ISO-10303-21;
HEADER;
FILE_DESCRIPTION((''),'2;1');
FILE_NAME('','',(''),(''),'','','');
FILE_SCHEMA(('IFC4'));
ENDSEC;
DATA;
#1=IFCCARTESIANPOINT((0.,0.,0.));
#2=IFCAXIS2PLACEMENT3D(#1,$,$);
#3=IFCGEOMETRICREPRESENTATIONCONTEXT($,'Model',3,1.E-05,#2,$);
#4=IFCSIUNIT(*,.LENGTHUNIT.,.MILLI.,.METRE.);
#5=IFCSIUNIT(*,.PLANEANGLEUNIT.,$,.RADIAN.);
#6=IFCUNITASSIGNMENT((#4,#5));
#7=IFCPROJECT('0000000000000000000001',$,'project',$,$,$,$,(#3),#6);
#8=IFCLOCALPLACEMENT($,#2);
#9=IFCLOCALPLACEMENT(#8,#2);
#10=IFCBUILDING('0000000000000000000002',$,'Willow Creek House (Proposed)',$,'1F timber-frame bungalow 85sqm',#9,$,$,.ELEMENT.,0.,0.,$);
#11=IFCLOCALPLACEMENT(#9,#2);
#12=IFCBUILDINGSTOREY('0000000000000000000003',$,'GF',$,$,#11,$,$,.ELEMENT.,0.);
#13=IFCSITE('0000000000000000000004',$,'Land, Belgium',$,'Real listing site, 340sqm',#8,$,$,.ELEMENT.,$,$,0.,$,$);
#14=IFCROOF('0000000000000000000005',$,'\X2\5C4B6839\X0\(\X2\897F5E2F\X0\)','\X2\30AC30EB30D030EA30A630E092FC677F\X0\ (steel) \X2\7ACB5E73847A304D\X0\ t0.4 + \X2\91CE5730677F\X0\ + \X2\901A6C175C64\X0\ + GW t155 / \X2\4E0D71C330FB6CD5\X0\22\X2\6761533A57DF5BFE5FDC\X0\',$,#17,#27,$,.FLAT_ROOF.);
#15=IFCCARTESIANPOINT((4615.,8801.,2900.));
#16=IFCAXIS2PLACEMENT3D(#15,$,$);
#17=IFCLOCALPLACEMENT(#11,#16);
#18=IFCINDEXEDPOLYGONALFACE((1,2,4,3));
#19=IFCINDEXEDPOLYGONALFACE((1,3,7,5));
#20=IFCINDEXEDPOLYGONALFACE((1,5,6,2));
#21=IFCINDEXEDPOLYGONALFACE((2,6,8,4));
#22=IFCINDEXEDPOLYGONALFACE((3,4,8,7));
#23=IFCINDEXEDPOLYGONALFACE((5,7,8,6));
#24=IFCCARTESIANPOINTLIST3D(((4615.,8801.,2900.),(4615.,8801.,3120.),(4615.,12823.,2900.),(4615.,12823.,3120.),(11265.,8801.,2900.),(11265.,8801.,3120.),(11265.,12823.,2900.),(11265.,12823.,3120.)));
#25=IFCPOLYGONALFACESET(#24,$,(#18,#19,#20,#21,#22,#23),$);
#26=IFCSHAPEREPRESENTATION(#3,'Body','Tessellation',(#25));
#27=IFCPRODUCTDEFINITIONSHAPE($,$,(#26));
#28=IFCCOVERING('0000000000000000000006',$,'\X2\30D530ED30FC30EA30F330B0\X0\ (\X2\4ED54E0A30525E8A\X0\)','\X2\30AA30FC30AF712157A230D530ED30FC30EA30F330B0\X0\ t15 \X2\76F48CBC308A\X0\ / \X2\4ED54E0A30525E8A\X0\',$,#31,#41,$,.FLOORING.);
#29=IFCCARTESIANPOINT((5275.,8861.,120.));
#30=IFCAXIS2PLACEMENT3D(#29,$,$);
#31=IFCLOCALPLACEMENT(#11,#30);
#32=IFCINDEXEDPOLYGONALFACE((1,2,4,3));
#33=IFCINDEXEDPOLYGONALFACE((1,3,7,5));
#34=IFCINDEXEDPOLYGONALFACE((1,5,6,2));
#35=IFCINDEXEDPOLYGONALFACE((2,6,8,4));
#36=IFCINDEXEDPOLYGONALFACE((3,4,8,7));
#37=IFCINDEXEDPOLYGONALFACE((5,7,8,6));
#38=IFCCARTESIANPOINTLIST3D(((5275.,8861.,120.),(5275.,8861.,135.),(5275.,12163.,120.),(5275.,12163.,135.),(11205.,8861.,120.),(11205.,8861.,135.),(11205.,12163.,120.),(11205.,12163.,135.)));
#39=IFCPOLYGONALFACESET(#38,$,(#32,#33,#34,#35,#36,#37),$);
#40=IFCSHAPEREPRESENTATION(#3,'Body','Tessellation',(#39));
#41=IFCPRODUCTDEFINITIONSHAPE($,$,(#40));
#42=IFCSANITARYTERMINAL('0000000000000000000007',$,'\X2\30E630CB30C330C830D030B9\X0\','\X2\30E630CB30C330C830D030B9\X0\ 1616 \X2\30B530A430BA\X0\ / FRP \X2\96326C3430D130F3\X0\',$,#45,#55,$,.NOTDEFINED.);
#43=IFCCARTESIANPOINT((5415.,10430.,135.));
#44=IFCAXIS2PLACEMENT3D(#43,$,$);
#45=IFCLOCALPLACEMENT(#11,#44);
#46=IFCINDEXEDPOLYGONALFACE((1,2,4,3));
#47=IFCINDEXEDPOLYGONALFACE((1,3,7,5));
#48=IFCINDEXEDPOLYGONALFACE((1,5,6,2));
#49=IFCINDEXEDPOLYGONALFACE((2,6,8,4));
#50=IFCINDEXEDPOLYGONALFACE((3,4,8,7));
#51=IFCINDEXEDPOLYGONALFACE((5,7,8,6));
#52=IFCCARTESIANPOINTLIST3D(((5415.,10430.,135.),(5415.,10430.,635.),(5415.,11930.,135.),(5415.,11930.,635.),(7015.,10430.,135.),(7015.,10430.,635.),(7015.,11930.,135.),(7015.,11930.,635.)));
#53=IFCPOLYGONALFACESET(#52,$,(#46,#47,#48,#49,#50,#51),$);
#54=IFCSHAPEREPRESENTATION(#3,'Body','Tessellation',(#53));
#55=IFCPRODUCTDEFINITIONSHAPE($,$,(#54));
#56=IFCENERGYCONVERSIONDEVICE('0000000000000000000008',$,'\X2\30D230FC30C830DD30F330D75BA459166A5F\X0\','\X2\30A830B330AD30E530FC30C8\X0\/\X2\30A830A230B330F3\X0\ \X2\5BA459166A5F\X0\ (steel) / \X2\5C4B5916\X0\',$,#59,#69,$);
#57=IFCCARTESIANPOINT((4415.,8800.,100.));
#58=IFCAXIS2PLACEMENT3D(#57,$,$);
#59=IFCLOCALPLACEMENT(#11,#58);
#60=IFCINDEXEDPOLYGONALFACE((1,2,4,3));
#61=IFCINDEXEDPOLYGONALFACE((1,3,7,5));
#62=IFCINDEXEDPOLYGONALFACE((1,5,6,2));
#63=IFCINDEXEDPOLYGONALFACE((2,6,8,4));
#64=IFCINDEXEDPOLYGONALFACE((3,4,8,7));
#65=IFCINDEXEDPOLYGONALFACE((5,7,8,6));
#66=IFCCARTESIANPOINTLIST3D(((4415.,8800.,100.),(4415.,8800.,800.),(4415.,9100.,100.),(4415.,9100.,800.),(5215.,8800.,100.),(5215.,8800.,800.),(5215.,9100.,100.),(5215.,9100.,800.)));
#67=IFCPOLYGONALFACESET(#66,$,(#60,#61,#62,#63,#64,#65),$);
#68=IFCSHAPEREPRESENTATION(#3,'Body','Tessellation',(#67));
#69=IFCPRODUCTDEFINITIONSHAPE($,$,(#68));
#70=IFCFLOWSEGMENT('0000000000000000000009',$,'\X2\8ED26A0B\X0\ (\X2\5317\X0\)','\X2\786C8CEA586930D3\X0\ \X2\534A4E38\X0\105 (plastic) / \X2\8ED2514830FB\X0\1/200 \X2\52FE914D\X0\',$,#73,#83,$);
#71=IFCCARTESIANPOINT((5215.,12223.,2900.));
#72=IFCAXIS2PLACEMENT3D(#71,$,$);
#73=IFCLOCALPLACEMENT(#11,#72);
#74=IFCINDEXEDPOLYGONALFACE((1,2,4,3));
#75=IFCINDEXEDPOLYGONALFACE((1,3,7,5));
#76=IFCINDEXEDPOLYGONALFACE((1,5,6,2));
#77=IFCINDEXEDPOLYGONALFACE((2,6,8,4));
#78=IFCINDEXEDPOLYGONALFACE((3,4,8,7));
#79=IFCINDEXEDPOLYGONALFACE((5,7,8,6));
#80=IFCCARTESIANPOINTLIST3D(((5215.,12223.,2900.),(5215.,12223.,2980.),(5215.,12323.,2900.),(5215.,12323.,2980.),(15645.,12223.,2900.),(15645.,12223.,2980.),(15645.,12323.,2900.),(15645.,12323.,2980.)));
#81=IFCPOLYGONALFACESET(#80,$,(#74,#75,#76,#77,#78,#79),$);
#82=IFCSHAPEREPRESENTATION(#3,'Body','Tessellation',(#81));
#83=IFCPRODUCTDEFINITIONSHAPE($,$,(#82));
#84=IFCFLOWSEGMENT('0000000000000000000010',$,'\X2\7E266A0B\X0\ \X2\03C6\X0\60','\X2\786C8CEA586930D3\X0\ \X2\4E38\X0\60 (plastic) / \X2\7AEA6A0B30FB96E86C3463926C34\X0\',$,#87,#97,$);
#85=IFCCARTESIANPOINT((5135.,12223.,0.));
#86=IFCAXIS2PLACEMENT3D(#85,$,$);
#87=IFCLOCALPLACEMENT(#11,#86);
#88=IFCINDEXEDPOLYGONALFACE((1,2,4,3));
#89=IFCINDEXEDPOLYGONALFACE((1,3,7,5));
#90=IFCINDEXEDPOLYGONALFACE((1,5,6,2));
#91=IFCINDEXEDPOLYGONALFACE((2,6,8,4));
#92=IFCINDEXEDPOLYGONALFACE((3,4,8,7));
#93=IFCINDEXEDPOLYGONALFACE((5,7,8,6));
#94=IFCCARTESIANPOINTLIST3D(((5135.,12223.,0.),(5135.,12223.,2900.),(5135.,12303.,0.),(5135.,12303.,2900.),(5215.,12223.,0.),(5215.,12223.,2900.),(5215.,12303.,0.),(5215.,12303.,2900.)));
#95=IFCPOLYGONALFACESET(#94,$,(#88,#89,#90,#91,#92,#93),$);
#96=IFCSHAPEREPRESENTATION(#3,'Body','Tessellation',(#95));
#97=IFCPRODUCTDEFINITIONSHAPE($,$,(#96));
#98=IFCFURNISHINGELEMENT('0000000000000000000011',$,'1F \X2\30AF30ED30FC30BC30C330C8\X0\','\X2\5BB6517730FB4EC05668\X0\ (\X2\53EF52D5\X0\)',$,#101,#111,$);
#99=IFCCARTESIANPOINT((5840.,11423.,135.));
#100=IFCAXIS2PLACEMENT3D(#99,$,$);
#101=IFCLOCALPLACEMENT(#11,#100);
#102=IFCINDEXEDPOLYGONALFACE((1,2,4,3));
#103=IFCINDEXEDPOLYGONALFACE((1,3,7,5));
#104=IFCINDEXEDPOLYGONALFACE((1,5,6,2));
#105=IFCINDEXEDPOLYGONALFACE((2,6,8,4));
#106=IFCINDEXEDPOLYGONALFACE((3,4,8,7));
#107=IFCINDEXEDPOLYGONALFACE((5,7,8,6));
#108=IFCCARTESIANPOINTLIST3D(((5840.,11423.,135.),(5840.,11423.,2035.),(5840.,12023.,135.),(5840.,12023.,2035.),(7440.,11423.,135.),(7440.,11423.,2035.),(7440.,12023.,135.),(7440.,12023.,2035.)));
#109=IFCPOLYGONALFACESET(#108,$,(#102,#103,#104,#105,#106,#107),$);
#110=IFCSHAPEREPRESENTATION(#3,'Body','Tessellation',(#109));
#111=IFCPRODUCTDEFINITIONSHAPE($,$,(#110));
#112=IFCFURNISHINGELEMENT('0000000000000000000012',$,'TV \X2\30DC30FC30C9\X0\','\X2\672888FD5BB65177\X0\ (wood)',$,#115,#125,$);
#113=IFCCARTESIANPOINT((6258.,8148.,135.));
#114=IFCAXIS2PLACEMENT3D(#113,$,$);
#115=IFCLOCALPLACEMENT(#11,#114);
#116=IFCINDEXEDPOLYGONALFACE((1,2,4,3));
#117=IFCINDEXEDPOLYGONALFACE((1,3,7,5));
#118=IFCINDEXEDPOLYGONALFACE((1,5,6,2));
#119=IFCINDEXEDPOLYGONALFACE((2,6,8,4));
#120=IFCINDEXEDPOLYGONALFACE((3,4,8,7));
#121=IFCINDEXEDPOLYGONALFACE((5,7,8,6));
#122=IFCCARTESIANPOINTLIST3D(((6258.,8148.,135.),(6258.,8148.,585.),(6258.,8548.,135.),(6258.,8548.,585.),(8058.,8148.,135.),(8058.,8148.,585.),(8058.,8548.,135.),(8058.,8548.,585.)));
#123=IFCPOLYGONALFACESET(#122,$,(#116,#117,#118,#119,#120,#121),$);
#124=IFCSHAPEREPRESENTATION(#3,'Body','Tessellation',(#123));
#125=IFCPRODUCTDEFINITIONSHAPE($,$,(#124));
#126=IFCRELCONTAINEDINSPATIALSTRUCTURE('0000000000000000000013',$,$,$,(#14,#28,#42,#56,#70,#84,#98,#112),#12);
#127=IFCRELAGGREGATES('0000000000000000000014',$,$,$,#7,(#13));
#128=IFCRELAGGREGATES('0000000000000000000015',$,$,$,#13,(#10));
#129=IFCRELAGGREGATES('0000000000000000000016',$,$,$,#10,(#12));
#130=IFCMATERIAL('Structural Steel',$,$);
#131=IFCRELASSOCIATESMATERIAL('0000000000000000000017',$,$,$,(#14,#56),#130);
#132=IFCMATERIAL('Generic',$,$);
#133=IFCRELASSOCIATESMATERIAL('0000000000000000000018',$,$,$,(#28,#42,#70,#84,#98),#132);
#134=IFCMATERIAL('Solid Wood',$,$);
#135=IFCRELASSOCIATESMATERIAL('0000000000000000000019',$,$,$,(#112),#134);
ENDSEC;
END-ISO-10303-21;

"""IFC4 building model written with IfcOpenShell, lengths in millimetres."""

from ifc_helpers import new_model, si_unit, frame, frame_2d, origin, place, context, project, spatial, rectangle, extrude, material, element, save


model = new_model("IFC4")

# Units and contexts
model_context = context("Model", 3, precision=1e-05, world=origin())
ifc_project = project(units=[si_unit("LENGTHUNIT", "METRE", prefix="MILLI"), si_unit("PLANEANGLEUNIT", "RADIAN")], contexts=[model_context])

# Site, building, storey
site_placement = place(None, origin())
site = spatial("IfcSite", under=ifc_project, at=site_placement, Name="Land, Belgium", ObjectType="Real listing site, 340sqm", CompositionType="ELEMENT", RefElevation=0.0)
building_placement = place(site_placement, origin())
building = spatial("IfcBuilding", under=site, at=building_placement, Name="Willow Creek House (Proposed)", ObjectType="1F timber-frame bungalow 85sqm", CompositionType="ELEMENT", ElevationOfRefHeight=0.0, ElevationOfTerrain=0.0)
storey_placement = place(building_placement, origin())
storey = spatial("IfcBuildingStorey", under=building, at=storey_placement, Name="GF", CompositionType="ELEMENT", Elevation=0.0)

# Shared definitions
ifc_material_1 = material(Name="Solid Wood")

# Roof
ifc_material_2 = material(Name="Structural Steel")
roof_placement = place(storey_placement, frame((4615.0, 8801.0, 2900.0)))
element("IfcRoof", 1, at=roof_placement, inside=storey, material=ifc_material_2, Name="屋根(西帯)", Description="ガルバリウム鋼板 (steel) 立平葺き t0.4 + 野地板 + 通気層 + GW t155 / 不燃・法22条区域対応", PredefinedType="FLAT_ROOF", context=model_context, shape_type="SweptSolid", body=[
    extrude(rectangle(XDim=6650.0, YDim=4022.0, at=frame_2d((3325.0, 2011.0))), frame((4615.0, 8801.0, 2900.0)), (0.0, 0.0, 1.0), 220.0),
])

# Covering
ifc_material_3 = material(Name="Generic")
covering_placement = place(storey_placement, frame((5275.0, 8861.0, 120.0)))
element("IfcCovering", 2, at=covering_placement, inside=storey, material=ifc_material_3, Name="フローリング (仕上げ床)", Description="オーク無垢フローリング t15 直貼り / 仕上げ床", PredefinedType="FLOORING", context=model_context, shape_type="SweptSolid", body=[
    extrude(rectangle(XDim=5930.0, YDim=3302.0, at=frame_2d((2965.0, 1651.0))), frame((5275.0, 8861.0, 120.0)), (0.0, 0.0, 1.0), 15.0),
])

# Sanitary terminal
sanitary_terminal_placement = place(storey_placement, frame((5415.0, 10430.0, 135.0)))
element("IfcSanitaryTerminal", 3, at=sanitary_terminal_placement, inside=storey, material=ifc_material_3, Name="ユニットバス", Description="ユニットバス 1616 サイズ / FRP 防水パン", PredefinedType="NOTDEFINED", context=model_context, shape_type="SweptSolid", body=[
    extrude(rectangle(XDim=1600.0, YDim=1500.0, at=frame_2d((800.0, 750.0))), frame((5415.0, 10430.0, 135.0)), (0.0, 0.0, 1.0), 500.0),
])

# Energy conversion device
energy_conversion_device_placement = place(storey_placement, frame((4415.0, 8800.0, 100.0)))
element("IfcEnergyConversionDevice", 4, at=energy_conversion_device_placement, inside=storey, material=ifc_material_2, Name="ヒートポンプ室外機", Description="エコキュート/エアコン 室外機 (steel) / 屋外", context=model_context, shape_type="SweptSolid", body=[
    extrude(rectangle(XDim=800.0, YDim=300.0, at=frame_2d((400.0, 150.0))), frame((4415.0, 8800.0, 100.0)), (0.0, 0.0, 1.0), 700.0),
])

# Flow segments
flow_segment_1_placement = place(storey_placement, frame((5215.0, 12223.0, 2900.0)))
element("IfcFlowSegment", 5, at=flow_segment_1_placement, inside=storey, material=ifc_material_3, Name="軒樋 (北)", Description="硬質塩ビ 半丸105 (plastic) / 軒先・1/200 勾配", context=model_context, shape_type="SweptSolid", body=[
    extrude(rectangle(XDim=10430.0, YDim=100.0, at=frame_2d((5215.0, 50.0))), frame((5215.0, 12223.0, 2900.0)), (0.0, 0.0, 1.0), 80.0),
])
flow_segment_2_placement = place(storey_placement, frame((5135.0, 12223.0, 0.0)))
element("IfcFlowSegment", 6, at=flow_segment_2_placement, inside=storey, material=ifc_material_3, Name="縦樋 φ60", Description="硬質塩ビ 丸60 (plastic) / 竪樋・雨水排水", context=model_context, shape_type="SweptSolid", body=[
    extrude(rectangle(XDim=80.0, YDim=80.0, at=frame_2d((40.0, 40.0))), frame((5135.0, 12223.0, 0.0)), (0.0, 0.0, 1.0), 2900.0),
])

# Furnishing elements
furnishing_1_placement = place(storey_placement, frame((5840.0, 11423.0, 135.0)))
element("IfcFurnishingElement", 7, at=furnishing_1_placement, inside=storey, material=ifc_material_3, Name="1F クローゼット", Description="家具・什器 (可動)", context=model_context, shape_type="SweptSolid", body=[
    extrude(rectangle(XDim=1600.0, YDim=600.0, at=frame_2d((800.0, 300.0))), frame((5840.0, 11423.0, 135.0)), (0.0, 0.0, 1.0), 1900.0),
])
furnishing_2_placement = place(storey_placement, frame((6258.0, 8148.0, 135.0)))
element("IfcFurnishingElement", 8, at=furnishing_2_placement, inside=storey, material=ifc_material_1, Name="TV ボード", Description="木製家具 (wood)", context=model_context, shape_type="SweptSolid", body=[
    extrude(rectangle(XDim=1800.0, YDim=400.0, at=frame_2d((900.0, 200.0))), frame((6258.0, 8148.0, 135.0)), (0.0, 0.0, 1.0), 450.0),
])

save(model, "model.ifc")
